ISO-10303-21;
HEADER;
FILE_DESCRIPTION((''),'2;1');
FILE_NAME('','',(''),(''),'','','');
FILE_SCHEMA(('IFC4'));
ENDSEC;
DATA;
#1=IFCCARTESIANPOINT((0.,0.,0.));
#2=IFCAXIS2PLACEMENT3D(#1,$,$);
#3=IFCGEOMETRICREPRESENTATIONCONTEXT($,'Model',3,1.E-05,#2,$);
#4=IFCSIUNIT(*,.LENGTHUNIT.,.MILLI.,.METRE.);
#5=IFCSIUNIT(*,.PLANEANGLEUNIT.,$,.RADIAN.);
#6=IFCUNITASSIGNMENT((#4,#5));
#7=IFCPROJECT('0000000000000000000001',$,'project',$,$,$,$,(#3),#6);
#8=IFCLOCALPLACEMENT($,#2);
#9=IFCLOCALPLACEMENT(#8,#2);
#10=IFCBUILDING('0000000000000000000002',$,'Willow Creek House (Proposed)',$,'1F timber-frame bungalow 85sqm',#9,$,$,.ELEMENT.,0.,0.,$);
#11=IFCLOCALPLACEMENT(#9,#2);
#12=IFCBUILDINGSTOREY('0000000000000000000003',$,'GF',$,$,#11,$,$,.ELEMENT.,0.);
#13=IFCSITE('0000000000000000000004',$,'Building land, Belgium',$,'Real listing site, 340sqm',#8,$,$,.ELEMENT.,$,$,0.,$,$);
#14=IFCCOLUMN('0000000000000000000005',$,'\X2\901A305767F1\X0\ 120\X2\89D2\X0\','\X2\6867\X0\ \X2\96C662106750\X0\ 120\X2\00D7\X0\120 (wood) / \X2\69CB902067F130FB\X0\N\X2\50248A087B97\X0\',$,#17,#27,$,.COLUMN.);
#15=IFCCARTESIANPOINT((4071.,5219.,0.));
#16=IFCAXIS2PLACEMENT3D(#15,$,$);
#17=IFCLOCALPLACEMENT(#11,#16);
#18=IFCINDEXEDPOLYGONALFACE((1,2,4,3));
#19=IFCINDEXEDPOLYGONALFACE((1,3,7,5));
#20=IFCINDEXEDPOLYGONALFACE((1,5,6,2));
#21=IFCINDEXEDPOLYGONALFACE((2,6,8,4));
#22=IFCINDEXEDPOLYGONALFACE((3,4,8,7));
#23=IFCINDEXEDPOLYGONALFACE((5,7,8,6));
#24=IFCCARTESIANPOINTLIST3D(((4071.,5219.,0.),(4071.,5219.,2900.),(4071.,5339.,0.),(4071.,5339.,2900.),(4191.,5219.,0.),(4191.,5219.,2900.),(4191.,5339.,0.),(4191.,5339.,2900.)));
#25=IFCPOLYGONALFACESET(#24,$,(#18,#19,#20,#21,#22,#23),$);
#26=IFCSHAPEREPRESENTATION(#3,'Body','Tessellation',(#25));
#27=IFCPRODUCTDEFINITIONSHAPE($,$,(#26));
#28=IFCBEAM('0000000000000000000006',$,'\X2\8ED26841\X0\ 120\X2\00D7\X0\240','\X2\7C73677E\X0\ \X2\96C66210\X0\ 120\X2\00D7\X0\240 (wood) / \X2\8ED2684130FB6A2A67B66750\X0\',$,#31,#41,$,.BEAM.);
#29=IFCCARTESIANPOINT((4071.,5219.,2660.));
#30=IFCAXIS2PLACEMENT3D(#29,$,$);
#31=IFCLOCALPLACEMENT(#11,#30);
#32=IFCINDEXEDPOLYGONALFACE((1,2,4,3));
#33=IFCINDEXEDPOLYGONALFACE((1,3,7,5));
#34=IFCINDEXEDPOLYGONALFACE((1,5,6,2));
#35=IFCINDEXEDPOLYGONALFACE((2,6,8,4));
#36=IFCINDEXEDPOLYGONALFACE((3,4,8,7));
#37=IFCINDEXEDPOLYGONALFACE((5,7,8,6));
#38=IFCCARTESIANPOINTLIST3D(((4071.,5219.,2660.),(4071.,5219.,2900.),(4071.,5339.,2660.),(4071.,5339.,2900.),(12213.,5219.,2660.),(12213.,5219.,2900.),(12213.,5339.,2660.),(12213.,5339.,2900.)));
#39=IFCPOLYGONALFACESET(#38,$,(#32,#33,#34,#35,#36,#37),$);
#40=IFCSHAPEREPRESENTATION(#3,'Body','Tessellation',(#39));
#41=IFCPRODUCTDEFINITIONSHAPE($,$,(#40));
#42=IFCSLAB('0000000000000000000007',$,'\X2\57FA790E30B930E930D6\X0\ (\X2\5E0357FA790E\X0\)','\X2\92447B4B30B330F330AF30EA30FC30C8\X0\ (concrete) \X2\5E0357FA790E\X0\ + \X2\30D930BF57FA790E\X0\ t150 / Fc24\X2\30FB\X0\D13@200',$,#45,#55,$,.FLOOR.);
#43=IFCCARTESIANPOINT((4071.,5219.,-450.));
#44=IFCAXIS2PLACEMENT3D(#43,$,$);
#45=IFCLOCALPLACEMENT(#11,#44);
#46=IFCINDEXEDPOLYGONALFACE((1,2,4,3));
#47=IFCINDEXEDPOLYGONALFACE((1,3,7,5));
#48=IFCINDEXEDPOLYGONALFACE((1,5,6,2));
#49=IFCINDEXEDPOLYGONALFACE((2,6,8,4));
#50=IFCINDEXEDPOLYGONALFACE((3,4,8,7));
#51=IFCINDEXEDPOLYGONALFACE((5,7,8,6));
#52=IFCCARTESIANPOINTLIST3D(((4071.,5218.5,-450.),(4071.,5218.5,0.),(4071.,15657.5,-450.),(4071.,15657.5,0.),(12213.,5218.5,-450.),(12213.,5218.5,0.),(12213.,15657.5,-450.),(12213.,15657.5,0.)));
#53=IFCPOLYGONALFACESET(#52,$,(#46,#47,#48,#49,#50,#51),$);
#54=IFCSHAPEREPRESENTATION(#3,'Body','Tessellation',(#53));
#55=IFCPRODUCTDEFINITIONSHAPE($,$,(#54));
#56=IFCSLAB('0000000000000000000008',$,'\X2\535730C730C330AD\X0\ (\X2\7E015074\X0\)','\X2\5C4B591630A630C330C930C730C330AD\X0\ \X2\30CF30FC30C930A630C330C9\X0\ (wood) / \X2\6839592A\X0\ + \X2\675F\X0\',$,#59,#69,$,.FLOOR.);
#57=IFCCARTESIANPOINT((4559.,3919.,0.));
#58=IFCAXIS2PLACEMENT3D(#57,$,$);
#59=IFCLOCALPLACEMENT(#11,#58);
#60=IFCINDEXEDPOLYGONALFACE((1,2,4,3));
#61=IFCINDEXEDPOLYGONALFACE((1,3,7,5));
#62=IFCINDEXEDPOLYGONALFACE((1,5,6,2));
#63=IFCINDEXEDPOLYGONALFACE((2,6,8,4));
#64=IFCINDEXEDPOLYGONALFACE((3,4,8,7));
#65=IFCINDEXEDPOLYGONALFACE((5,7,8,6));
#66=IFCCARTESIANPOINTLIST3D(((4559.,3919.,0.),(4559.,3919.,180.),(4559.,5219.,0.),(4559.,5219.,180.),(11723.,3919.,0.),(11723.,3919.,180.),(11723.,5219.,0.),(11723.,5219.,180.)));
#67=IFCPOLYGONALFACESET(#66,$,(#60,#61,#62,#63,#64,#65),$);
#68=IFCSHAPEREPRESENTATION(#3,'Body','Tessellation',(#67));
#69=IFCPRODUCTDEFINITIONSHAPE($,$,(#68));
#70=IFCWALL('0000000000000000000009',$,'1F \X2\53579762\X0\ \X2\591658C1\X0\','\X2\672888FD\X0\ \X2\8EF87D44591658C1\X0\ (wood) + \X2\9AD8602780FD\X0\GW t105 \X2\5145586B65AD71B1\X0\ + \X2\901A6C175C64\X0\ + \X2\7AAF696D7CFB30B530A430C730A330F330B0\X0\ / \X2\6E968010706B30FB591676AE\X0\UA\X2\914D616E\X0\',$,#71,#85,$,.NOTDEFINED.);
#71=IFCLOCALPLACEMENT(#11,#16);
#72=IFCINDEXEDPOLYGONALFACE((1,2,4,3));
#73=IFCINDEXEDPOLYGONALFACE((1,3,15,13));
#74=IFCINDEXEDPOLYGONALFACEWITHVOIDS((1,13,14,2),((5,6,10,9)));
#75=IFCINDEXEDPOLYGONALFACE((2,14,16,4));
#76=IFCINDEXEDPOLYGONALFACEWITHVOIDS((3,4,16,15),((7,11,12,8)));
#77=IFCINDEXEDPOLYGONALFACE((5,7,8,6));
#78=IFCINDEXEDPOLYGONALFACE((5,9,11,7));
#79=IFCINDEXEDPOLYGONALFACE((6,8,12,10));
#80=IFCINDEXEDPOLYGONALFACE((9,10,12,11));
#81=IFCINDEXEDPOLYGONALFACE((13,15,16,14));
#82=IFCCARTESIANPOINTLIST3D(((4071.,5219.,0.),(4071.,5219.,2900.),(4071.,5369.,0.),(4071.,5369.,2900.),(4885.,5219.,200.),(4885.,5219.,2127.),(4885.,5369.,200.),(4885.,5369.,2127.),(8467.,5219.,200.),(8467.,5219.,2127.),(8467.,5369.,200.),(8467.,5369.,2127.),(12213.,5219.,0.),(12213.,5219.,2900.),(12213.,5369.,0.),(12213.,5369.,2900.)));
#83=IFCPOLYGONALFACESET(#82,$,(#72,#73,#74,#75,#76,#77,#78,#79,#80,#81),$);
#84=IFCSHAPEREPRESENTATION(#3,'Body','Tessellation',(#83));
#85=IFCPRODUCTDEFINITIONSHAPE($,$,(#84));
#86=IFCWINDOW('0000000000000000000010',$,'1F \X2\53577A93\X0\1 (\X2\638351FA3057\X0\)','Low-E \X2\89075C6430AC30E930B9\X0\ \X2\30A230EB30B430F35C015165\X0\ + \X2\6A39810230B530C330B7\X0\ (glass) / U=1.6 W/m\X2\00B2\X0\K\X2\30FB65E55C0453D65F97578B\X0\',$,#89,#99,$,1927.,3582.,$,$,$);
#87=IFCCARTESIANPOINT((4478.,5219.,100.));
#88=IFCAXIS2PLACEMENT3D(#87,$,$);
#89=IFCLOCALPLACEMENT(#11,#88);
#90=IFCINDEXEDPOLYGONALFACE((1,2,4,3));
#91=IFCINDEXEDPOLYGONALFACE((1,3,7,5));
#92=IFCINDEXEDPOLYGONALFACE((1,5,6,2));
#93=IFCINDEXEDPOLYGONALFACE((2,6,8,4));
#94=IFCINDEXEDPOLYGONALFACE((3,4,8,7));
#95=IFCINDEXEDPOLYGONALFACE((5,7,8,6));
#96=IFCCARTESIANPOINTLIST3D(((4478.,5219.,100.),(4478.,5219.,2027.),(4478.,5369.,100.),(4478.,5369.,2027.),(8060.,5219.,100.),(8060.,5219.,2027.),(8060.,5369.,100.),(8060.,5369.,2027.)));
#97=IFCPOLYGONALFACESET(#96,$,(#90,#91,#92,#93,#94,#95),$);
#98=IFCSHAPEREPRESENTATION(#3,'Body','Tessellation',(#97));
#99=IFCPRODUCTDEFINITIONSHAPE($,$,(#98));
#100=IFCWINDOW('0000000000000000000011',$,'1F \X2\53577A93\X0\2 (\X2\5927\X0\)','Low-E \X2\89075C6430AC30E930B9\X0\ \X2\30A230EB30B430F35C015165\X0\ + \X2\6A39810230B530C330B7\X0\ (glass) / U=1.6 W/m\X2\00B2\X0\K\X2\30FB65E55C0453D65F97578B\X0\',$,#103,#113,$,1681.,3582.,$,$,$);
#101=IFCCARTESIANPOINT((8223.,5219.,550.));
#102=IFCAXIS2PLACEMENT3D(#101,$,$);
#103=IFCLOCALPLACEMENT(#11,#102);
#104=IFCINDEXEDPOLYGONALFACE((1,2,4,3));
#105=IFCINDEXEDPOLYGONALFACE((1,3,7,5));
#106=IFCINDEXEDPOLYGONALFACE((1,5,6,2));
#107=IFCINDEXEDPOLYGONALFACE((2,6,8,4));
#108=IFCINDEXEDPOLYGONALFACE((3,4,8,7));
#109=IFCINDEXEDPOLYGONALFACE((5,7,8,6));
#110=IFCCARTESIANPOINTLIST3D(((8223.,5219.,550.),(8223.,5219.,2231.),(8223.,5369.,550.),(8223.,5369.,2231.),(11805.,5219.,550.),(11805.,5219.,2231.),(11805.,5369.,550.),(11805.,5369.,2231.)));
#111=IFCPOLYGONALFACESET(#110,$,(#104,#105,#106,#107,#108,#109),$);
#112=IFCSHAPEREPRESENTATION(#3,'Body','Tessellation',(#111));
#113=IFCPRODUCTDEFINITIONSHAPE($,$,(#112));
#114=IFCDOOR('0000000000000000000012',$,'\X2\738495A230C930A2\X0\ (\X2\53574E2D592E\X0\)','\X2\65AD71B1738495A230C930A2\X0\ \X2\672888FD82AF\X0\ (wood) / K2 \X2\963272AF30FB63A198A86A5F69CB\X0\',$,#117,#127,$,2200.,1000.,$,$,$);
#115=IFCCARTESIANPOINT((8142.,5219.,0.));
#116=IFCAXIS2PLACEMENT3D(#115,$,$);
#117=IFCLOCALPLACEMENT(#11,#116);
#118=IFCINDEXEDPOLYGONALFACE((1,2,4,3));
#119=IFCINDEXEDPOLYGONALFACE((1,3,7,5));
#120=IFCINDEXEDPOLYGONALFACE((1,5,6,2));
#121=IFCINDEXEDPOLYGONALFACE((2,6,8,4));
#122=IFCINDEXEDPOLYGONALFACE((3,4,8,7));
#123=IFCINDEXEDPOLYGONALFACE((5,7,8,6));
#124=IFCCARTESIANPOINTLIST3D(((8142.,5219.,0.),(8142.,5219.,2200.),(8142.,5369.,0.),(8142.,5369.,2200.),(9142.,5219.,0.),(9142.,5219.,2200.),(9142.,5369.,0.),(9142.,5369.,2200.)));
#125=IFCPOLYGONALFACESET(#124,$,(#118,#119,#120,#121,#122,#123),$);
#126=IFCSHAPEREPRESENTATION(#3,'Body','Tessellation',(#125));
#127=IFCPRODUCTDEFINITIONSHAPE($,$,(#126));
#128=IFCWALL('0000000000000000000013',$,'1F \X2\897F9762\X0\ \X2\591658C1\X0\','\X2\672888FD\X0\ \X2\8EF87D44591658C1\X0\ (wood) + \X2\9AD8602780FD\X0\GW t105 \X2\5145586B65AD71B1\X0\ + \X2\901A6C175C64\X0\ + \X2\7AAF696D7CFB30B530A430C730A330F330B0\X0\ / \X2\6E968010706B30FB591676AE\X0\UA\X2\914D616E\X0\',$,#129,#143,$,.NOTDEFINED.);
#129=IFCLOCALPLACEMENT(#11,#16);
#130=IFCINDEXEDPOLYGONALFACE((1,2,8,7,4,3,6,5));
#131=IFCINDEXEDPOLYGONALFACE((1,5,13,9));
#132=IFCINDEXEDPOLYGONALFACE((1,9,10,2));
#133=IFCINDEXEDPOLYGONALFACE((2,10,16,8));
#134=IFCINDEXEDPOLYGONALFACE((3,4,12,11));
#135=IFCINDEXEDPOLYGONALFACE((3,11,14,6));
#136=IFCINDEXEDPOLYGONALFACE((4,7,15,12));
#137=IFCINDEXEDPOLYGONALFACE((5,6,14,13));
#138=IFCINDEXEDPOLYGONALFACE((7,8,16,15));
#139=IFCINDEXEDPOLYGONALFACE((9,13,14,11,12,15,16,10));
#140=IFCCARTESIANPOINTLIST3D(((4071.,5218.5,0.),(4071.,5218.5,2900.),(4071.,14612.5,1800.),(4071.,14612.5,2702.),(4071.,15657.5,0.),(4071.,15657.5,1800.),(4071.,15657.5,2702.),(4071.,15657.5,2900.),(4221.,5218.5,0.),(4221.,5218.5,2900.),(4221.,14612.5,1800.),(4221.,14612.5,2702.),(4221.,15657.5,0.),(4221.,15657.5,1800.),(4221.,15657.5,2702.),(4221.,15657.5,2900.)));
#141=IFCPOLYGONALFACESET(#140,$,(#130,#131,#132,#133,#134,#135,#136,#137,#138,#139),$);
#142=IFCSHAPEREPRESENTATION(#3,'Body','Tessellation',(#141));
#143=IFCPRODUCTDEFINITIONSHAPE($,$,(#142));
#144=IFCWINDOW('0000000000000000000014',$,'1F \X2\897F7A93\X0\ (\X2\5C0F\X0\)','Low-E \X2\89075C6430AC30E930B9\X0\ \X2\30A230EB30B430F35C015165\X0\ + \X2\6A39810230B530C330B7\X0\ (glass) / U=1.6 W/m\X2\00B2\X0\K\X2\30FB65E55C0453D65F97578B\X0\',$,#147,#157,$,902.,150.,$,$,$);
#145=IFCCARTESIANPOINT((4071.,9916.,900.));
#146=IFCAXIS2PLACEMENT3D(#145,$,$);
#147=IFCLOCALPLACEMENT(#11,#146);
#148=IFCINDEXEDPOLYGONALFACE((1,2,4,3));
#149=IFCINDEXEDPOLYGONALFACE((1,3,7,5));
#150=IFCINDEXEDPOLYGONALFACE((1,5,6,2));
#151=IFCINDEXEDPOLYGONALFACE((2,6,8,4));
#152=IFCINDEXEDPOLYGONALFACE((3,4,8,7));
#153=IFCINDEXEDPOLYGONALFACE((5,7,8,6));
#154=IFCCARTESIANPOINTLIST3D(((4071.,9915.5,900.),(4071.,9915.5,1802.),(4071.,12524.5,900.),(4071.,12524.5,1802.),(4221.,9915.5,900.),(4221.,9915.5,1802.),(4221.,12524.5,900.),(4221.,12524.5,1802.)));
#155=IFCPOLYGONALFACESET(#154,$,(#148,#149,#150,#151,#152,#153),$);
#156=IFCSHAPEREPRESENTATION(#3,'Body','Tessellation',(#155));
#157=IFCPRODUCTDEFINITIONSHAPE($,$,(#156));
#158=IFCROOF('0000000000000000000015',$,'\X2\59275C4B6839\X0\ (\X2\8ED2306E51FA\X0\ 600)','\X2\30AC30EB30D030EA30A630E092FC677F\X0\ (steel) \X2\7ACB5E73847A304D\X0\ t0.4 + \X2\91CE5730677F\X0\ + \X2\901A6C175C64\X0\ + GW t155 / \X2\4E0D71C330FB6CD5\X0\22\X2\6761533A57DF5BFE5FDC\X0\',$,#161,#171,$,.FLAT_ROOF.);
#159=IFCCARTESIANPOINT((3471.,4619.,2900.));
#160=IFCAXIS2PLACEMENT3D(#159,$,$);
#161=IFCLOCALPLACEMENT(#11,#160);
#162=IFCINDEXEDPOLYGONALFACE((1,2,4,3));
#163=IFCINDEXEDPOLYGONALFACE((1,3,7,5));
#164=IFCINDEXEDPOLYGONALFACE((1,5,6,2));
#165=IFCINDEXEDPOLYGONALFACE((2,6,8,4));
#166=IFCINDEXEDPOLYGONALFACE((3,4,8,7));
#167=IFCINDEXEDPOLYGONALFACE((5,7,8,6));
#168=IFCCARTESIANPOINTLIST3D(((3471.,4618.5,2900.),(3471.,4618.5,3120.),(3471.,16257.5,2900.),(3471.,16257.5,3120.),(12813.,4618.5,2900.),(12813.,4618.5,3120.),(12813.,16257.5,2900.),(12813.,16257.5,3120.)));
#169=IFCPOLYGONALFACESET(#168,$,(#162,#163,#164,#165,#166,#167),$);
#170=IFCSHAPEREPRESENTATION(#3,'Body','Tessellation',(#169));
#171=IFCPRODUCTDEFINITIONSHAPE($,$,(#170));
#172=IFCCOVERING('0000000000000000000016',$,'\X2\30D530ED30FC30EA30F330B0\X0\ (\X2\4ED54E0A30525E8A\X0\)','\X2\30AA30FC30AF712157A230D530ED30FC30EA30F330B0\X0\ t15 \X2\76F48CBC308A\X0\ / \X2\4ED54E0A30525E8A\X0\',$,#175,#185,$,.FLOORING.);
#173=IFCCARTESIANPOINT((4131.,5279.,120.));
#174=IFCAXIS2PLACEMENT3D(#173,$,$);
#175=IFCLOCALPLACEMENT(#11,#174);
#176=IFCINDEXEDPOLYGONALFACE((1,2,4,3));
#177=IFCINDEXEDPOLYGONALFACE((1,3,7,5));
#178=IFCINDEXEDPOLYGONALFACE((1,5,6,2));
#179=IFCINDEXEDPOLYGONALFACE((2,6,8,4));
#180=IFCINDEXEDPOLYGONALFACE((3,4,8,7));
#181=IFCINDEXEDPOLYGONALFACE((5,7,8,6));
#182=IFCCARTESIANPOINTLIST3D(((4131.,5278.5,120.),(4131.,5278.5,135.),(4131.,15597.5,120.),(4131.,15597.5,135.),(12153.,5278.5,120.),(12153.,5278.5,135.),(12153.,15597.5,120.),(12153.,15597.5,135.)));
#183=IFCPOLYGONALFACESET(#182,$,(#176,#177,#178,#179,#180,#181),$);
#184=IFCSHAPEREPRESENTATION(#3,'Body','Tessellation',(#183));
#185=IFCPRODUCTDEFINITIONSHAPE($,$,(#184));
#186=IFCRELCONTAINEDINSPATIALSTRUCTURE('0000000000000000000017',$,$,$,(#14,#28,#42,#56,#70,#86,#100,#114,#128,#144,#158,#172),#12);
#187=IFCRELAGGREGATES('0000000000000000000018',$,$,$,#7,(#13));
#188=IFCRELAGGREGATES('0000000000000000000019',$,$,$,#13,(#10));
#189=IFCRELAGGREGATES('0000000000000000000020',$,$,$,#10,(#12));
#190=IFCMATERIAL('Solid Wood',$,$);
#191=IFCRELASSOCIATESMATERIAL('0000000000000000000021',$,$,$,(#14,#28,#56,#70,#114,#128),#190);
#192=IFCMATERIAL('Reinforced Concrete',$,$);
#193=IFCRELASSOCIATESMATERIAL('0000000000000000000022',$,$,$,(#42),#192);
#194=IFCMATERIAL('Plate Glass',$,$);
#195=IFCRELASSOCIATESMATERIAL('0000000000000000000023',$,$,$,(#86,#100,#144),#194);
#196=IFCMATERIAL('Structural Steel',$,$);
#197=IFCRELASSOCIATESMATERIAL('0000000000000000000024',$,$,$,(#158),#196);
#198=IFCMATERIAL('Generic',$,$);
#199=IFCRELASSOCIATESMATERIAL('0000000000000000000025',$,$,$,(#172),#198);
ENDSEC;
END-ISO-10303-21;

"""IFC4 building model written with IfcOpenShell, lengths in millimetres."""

from ifc_helpers import new_model, si_unit, frame, frame_2d, origin, place, context, project, spatial, rectangle, extrude, material, element, fill, save


model = new_model("IFC4")

# Units and contexts
model_context = context("Model", 3, precision=1e-05, world=origin())
ifc_project = project(units=[si_unit("LENGTHUNIT", "METRE", prefix="MILLI"), si_unit("PLANEANGLEUNIT", "RADIAN")], contexts=[model_context])

# Site, building, storey
site_placement = place(None, origin())
site = spatial("IfcSite", under=ifc_project, at=site_placement, Name="Building land, Belgium", ObjectType="Real listing site, 340sqm", CompositionType="ELEMENT", RefElevation=0.0)
building_placement = place(site_placement, origin())
building = spatial("IfcBuilding", under=site, at=building_placement, Name="Willow Creek House (Proposed)", ObjectType="1F timber-frame bungalow 85sqm", CompositionType="ELEMENT", ElevationOfRefHeight=0.0, ElevationOfTerrain=0.0)
storey_placement = place(building_placement, origin())
storey = spatial("IfcBuildingStorey", under=building, at=storey_placement, Name="GF", CompositionType="ELEMENT", Elevation=0.0)

# Column
ifc_material_1 = material(Name="Solid Wood")
column_1_placement = place(storey_placement, frame((4071.0, 5219.0, 0.0)))
element("IfcColumn", 1, at=column_1_placement, inside=storey, material=ifc_material_1, Name="通し柱 120角", Description="桧 集成材 120×120 (wood) / 構造柱・N値計算", PredefinedType="COLUMN", context=model_context, shape_type="SweptSolid", body=[
    extrude(rectangle(XDim=120.0, YDim=120.0, at=frame_2d((60.0, 60.0))), frame((4071.0, 5219.0, 0.0)), (0.0, 0.0, 1.0), 2900.0),
])

# Beam
beam_1_placement = place(storey_placement, frame((4071.0, 5219.0, 2660.0)))
element("IfcBeam", 2, at=beam_1_placement, inside=storey, material=ifc_material_1, Name="軒桁 120×240", Description="米松 集成 120×240 (wood) / 軒桁・横架材", PredefinedType="BEAM", context=model_context, shape_type="SweptSolid", body=[
    extrude(rectangle(XDim=8142.0, YDim=120.0, at=frame_2d((4071.0, 60.0))), frame((4071.0, 5219.0, 2660.0)), (0.0, 0.0, 1.0), 240.0),
])

# Slabs
ifc_material_2 = material(Name="Reinforced Concrete")
slab_1_placement = place(storey_placement, frame((4071.0, 5219.0, -450.0)))
element("IfcSlab", 3, at=slab_1_placement, inside=storey, material=ifc_material_2, Name="基礎スラブ (布基礎)", Description="鉄筋コンクリート (concrete) 布基礎 + ベタ基礎 t150 / Fc24・D13@200", PredefinedType="FLOOR", context=model_context, shape_type="SweptSolid", body=[
    extrude(rectangle(XDim=8142.0, YDim=10439.0, at=frame_2d((4071.0, 5219.0))), frame((4071.0, 5219.0, -450.0)), (0.0, 0.0, 1.0), 450.0),
])
slab_2_placement = place(storey_placement, frame((4559.0, 3919.0, 0.0)))
element("IfcSlab", 4, at=slab_2_placement, inside=storey, material=ifc_material_1, Name="南デッキ (縁側)", Description="屋外ウッドデッキ ハードウッド (wood) / 根太 + 束", PredefinedType="FLOOR", context=model_context, shape_type="SweptSolid", body=[
    extrude(rectangle(XDim=7164.0, YDim=1300.0, at=frame_2d((3582.0, 650.0))), frame((4559.0, 3919.0, 0.0)), (0.0, 0.0, 1.0), 180.0),
])

# Wall, openings, windows, door
wall_1_placement = place(storey_placement, frame((4071.0, 5219.0, 0.0)))
wall_1 = element("IfcWall", 5, at=wall_1_placement, inside=storey, material=ifc_material_1, Name="1F 南面 外壁", Description="木製 軸組外壁 (wood) + 高性能GW t105 充填断熱 + 通気層 + 窯業系サイディング / 準耐火・外皮UA配慮", PredefinedType="NOTDEFINED", context=model_context, shape_type="SweptSolid", body=[
    extrude(rectangle(XDim=8142.0, YDim=150.0, at=frame_2d((4071.0, 75.0))), frame((4071.0, 5219.0, 0.0)), (0.0, 0.0, 1.0), 2900.0),
])
opening_1_placement = place(storey_placement, frame((4478.0, 5219.0, 100.0)))
opening_1 = element("IfcOpeningElement", 6, at=opening_1_placement, cuts=wall_1, PredefinedType="NOTDEFINED", context=model_context, shape_type="SweptSolid", body=[
    extrude(rectangle(XDim=3582.0, YDim=150.0, at=frame_2d((1791.0, 75.0))), frame((4478.0, 5219.0, 100.0)), (0.0, 0.0, 1.0), 1927.0),
])
opening_2_placement = place(storey_placement, frame((8223.0, 5219.0, 550.0)))
opening_2 = element("IfcOpeningElement", 7, at=opening_2_placement, cuts=wall_1, PredefinedType="NOTDEFINED", context=model_context, shape_type="SweptSolid", body=[
    extrude(rectangle(XDim=3582.0, YDim=150.0, at=frame_2d((1791.0, 75.0))), frame((8223.0, 5219.0, 550.0)), (0.0, 0.0, 1.0), 1681.0),
])
opening_3_placement = place(storey_placement, frame((8142.0, 5219.0, 0.0)))
opening_3 = element("IfcOpeningElement", 8, at=opening_3_placement, cuts=wall_1, PredefinedType="NOTDEFINED", context=model_context, shape_type="SweptSolid", body=[
    extrude(rectangle(XDim=1000.0, YDim=150.0, at=frame_2d((500.0, 75.0))), frame((8142.0, 5219.0, 0.0)), (0.0, 0.0, 1.0), 2200.0),
])
ifc_material_3 = material(Name="Plate Glass")
window_1_placement = place(storey_placement, frame((4478.0, 5219.0, 100.0)))
window_1 = element("IfcWindow", 9, at=window_1_placement, inside=storey, material=ifc_material_3, Name="1F 南窓1 (掃出し)", Description="Low-E 複層ガラス アルゴン封入 + 樹脂サッシ (glass) / U=1.6 W/m²K・日射取得型", OverallHeight=1927.0, OverallWidth=3582.0, context=model_context, shape_type="SweptSolid", body=[
    extrude(rectangle(XDim=3582.0, YDim=150.0, at=frame_2d((1791.0, 75.0))), frame((4478.0, 5219.0, 100.0)), (0.0, 0.0, 1.0), 1927.0),
])
fill(opening_1, window_1)
window_2_placement = place(storey_placement, frame((8223.0, 5219.0, 550.0)))
window_2 = element("IfcWindow", 10, at=window_2_placement, inside=storey, material=ifc_material_3, Name="1F 南窓2 (大)", Description="Low-E 複層ガラス アルゴン封入 + 樹脂サッシ (glass) / U=1.6 W/m²K・日射取得型", OverallHeight=1681.0, OverallWidth=3582.0, context=model_context, shape_type="SweptSolid", body=[
    extrude(rectangle(XDim=3582.0, YDim=150.0, at=frame_2d((1791.0, 75.0))), frame((8223.0, 5219.0, 550.0)), (0.0, 0.0, 1.0), 1681.0),
])
fill(opening_2, window_2)
door_placement = place(storey_placement, frame((8142.0, 5219.0, 0.0)))
door = element("IfcDoor", 11, at=door_placement, inside=storey, material=ifc_material_1, Name="玄関ドア (南中央)", Description="断熱玄関ドア 木製芯 (wood) / K2 防犯・採風機構", OverallHeight=2200.0, OverallWidth=1000.0, context=model_context, shape_type="SweptSolid", body=[
    extrude(rectangle(XDim=1000.0, YDim=150.0, at=frame_2d((500.0, 75.0))), frame((8142.0, 5219.0, 0.0)), (0.0, 0.0, 1.0), 2200.0),
])
fill(opening_3, door)

# Wall, opening, window
wall_2_placement = place(storey_placement, frame((4071.0, 5219.0, 0.0)))
wall_2 = element("IfcWall", 12, at=wall_2_placement, inside=storey, material=ifc_material_1, Name="1F 西面 外壁", Description="木製 軸組外壁 (wood) + 高性能GW t105 充填断熱 + 通気層 + 窯業系サイディング / 準耐火・外皮UA配慮", PredefinedType="NOTDEFINED", context=model_context, shape_type="SweptSolid", body=[
    extrude(rectangle(XDim=150.0, YDim=10439.0, at=frame_2d((75.0, 5219.0))), frame((4071.0, 5219.0, 0.0)), (0.0, 0.0, 1.0), 2900.0),
])
opening_4_placement = place(storey_placement, frame((4071.0, 9916.0, 900.0)))
opening_4 = element("IfcOpeningElement", 13, at=opening_4_placement, cuts=wall_2, PredefinedType="NOTDEFINED", context=model_context, shape_type="SweptSolid", body=[
    extrude(rectangle(XDim=150.0, YDim=2609.0, at=frame_2d((75.0, 1304.0))), frame((4071.0, 9916.0, 900.0)), (0.0, 0.0, 1.0), 902.0),
])
window_3_placement = place(storey_placement, frame((4071.0, 9916.0, 900.0)))
window_3 = element("IfcWindow", 14, at=window_3_placement, inside=storey, material=ifc_material_3, Name="1F 西窓 (小)", Description="Low-E 複層ガラス アルゴン封入 + 樹脂サッシ (glass) / U=1.6 W/m²K・日射取得型", OverallHeight=902.0, OverallWidth=150.0, context=model_context, shape_type="SweptSolid", body=[
    extrude(rectangle(XDim=150.0, YDim=2609.0, at=frame_2d((75.0, 1304.0))), frame((4071.0, 9916.0, 900.0)), (0.0, 0.0, 1.0), 902.0),
])
fill(opening_4, window_3)

# Roof
ifc_material_4 = material(Name="Structural Steel")
roof_placement = place(storey_placement, frame((3471.0, 4619.0, 2900.0)))
element("IfcRoof", 15, at=roof_placement, inside=storey, material=ifc_material_4, Name="大屋根 (軒の出 600)", Description="ガルバリウム鋼板 (steel) 立平葺き t0.4 + 野地板 + 通気層 + GW t155 / 不燃・法22条区域対応", PredefinedType="FLAT_ROOF", context=model_context, shape_type="SweptSolid", body=[
    extrude(rectangle(XDim=9342.0, YDim=11639.0, at=frame_2d((4671.0, 5819.0))), frame((3471.0, 4619.0, 2900.0)), (0.0, 0.0, 1.0), 220.0),
])

# Covering
ifc_material_5 = material(Name="Generic")
covering_1_placement = place(storey_placement, frame((4131.0, 5279.0, 120.0)))
element("IfcCovering", 16, at=covering_1_placement, inside=storey, material=ifc_material_5, Name="フローリング (仕上げ床)", Description="オーク無垢フローリング t15 直貼り / 仕上げ床", PredefinedType="FLOORING", context=model_context, shape_type="SweptSolid", body=[
    extrude(rectangle(XDim=8022.0, YDim=10319.0, at=frame_2d((4011.0, 5159.0))), frame((4131.0, 5279.0, 120.0)), (0.0, 0.0, 1.0), 15.0),
])

save(model, "model.ifc")
